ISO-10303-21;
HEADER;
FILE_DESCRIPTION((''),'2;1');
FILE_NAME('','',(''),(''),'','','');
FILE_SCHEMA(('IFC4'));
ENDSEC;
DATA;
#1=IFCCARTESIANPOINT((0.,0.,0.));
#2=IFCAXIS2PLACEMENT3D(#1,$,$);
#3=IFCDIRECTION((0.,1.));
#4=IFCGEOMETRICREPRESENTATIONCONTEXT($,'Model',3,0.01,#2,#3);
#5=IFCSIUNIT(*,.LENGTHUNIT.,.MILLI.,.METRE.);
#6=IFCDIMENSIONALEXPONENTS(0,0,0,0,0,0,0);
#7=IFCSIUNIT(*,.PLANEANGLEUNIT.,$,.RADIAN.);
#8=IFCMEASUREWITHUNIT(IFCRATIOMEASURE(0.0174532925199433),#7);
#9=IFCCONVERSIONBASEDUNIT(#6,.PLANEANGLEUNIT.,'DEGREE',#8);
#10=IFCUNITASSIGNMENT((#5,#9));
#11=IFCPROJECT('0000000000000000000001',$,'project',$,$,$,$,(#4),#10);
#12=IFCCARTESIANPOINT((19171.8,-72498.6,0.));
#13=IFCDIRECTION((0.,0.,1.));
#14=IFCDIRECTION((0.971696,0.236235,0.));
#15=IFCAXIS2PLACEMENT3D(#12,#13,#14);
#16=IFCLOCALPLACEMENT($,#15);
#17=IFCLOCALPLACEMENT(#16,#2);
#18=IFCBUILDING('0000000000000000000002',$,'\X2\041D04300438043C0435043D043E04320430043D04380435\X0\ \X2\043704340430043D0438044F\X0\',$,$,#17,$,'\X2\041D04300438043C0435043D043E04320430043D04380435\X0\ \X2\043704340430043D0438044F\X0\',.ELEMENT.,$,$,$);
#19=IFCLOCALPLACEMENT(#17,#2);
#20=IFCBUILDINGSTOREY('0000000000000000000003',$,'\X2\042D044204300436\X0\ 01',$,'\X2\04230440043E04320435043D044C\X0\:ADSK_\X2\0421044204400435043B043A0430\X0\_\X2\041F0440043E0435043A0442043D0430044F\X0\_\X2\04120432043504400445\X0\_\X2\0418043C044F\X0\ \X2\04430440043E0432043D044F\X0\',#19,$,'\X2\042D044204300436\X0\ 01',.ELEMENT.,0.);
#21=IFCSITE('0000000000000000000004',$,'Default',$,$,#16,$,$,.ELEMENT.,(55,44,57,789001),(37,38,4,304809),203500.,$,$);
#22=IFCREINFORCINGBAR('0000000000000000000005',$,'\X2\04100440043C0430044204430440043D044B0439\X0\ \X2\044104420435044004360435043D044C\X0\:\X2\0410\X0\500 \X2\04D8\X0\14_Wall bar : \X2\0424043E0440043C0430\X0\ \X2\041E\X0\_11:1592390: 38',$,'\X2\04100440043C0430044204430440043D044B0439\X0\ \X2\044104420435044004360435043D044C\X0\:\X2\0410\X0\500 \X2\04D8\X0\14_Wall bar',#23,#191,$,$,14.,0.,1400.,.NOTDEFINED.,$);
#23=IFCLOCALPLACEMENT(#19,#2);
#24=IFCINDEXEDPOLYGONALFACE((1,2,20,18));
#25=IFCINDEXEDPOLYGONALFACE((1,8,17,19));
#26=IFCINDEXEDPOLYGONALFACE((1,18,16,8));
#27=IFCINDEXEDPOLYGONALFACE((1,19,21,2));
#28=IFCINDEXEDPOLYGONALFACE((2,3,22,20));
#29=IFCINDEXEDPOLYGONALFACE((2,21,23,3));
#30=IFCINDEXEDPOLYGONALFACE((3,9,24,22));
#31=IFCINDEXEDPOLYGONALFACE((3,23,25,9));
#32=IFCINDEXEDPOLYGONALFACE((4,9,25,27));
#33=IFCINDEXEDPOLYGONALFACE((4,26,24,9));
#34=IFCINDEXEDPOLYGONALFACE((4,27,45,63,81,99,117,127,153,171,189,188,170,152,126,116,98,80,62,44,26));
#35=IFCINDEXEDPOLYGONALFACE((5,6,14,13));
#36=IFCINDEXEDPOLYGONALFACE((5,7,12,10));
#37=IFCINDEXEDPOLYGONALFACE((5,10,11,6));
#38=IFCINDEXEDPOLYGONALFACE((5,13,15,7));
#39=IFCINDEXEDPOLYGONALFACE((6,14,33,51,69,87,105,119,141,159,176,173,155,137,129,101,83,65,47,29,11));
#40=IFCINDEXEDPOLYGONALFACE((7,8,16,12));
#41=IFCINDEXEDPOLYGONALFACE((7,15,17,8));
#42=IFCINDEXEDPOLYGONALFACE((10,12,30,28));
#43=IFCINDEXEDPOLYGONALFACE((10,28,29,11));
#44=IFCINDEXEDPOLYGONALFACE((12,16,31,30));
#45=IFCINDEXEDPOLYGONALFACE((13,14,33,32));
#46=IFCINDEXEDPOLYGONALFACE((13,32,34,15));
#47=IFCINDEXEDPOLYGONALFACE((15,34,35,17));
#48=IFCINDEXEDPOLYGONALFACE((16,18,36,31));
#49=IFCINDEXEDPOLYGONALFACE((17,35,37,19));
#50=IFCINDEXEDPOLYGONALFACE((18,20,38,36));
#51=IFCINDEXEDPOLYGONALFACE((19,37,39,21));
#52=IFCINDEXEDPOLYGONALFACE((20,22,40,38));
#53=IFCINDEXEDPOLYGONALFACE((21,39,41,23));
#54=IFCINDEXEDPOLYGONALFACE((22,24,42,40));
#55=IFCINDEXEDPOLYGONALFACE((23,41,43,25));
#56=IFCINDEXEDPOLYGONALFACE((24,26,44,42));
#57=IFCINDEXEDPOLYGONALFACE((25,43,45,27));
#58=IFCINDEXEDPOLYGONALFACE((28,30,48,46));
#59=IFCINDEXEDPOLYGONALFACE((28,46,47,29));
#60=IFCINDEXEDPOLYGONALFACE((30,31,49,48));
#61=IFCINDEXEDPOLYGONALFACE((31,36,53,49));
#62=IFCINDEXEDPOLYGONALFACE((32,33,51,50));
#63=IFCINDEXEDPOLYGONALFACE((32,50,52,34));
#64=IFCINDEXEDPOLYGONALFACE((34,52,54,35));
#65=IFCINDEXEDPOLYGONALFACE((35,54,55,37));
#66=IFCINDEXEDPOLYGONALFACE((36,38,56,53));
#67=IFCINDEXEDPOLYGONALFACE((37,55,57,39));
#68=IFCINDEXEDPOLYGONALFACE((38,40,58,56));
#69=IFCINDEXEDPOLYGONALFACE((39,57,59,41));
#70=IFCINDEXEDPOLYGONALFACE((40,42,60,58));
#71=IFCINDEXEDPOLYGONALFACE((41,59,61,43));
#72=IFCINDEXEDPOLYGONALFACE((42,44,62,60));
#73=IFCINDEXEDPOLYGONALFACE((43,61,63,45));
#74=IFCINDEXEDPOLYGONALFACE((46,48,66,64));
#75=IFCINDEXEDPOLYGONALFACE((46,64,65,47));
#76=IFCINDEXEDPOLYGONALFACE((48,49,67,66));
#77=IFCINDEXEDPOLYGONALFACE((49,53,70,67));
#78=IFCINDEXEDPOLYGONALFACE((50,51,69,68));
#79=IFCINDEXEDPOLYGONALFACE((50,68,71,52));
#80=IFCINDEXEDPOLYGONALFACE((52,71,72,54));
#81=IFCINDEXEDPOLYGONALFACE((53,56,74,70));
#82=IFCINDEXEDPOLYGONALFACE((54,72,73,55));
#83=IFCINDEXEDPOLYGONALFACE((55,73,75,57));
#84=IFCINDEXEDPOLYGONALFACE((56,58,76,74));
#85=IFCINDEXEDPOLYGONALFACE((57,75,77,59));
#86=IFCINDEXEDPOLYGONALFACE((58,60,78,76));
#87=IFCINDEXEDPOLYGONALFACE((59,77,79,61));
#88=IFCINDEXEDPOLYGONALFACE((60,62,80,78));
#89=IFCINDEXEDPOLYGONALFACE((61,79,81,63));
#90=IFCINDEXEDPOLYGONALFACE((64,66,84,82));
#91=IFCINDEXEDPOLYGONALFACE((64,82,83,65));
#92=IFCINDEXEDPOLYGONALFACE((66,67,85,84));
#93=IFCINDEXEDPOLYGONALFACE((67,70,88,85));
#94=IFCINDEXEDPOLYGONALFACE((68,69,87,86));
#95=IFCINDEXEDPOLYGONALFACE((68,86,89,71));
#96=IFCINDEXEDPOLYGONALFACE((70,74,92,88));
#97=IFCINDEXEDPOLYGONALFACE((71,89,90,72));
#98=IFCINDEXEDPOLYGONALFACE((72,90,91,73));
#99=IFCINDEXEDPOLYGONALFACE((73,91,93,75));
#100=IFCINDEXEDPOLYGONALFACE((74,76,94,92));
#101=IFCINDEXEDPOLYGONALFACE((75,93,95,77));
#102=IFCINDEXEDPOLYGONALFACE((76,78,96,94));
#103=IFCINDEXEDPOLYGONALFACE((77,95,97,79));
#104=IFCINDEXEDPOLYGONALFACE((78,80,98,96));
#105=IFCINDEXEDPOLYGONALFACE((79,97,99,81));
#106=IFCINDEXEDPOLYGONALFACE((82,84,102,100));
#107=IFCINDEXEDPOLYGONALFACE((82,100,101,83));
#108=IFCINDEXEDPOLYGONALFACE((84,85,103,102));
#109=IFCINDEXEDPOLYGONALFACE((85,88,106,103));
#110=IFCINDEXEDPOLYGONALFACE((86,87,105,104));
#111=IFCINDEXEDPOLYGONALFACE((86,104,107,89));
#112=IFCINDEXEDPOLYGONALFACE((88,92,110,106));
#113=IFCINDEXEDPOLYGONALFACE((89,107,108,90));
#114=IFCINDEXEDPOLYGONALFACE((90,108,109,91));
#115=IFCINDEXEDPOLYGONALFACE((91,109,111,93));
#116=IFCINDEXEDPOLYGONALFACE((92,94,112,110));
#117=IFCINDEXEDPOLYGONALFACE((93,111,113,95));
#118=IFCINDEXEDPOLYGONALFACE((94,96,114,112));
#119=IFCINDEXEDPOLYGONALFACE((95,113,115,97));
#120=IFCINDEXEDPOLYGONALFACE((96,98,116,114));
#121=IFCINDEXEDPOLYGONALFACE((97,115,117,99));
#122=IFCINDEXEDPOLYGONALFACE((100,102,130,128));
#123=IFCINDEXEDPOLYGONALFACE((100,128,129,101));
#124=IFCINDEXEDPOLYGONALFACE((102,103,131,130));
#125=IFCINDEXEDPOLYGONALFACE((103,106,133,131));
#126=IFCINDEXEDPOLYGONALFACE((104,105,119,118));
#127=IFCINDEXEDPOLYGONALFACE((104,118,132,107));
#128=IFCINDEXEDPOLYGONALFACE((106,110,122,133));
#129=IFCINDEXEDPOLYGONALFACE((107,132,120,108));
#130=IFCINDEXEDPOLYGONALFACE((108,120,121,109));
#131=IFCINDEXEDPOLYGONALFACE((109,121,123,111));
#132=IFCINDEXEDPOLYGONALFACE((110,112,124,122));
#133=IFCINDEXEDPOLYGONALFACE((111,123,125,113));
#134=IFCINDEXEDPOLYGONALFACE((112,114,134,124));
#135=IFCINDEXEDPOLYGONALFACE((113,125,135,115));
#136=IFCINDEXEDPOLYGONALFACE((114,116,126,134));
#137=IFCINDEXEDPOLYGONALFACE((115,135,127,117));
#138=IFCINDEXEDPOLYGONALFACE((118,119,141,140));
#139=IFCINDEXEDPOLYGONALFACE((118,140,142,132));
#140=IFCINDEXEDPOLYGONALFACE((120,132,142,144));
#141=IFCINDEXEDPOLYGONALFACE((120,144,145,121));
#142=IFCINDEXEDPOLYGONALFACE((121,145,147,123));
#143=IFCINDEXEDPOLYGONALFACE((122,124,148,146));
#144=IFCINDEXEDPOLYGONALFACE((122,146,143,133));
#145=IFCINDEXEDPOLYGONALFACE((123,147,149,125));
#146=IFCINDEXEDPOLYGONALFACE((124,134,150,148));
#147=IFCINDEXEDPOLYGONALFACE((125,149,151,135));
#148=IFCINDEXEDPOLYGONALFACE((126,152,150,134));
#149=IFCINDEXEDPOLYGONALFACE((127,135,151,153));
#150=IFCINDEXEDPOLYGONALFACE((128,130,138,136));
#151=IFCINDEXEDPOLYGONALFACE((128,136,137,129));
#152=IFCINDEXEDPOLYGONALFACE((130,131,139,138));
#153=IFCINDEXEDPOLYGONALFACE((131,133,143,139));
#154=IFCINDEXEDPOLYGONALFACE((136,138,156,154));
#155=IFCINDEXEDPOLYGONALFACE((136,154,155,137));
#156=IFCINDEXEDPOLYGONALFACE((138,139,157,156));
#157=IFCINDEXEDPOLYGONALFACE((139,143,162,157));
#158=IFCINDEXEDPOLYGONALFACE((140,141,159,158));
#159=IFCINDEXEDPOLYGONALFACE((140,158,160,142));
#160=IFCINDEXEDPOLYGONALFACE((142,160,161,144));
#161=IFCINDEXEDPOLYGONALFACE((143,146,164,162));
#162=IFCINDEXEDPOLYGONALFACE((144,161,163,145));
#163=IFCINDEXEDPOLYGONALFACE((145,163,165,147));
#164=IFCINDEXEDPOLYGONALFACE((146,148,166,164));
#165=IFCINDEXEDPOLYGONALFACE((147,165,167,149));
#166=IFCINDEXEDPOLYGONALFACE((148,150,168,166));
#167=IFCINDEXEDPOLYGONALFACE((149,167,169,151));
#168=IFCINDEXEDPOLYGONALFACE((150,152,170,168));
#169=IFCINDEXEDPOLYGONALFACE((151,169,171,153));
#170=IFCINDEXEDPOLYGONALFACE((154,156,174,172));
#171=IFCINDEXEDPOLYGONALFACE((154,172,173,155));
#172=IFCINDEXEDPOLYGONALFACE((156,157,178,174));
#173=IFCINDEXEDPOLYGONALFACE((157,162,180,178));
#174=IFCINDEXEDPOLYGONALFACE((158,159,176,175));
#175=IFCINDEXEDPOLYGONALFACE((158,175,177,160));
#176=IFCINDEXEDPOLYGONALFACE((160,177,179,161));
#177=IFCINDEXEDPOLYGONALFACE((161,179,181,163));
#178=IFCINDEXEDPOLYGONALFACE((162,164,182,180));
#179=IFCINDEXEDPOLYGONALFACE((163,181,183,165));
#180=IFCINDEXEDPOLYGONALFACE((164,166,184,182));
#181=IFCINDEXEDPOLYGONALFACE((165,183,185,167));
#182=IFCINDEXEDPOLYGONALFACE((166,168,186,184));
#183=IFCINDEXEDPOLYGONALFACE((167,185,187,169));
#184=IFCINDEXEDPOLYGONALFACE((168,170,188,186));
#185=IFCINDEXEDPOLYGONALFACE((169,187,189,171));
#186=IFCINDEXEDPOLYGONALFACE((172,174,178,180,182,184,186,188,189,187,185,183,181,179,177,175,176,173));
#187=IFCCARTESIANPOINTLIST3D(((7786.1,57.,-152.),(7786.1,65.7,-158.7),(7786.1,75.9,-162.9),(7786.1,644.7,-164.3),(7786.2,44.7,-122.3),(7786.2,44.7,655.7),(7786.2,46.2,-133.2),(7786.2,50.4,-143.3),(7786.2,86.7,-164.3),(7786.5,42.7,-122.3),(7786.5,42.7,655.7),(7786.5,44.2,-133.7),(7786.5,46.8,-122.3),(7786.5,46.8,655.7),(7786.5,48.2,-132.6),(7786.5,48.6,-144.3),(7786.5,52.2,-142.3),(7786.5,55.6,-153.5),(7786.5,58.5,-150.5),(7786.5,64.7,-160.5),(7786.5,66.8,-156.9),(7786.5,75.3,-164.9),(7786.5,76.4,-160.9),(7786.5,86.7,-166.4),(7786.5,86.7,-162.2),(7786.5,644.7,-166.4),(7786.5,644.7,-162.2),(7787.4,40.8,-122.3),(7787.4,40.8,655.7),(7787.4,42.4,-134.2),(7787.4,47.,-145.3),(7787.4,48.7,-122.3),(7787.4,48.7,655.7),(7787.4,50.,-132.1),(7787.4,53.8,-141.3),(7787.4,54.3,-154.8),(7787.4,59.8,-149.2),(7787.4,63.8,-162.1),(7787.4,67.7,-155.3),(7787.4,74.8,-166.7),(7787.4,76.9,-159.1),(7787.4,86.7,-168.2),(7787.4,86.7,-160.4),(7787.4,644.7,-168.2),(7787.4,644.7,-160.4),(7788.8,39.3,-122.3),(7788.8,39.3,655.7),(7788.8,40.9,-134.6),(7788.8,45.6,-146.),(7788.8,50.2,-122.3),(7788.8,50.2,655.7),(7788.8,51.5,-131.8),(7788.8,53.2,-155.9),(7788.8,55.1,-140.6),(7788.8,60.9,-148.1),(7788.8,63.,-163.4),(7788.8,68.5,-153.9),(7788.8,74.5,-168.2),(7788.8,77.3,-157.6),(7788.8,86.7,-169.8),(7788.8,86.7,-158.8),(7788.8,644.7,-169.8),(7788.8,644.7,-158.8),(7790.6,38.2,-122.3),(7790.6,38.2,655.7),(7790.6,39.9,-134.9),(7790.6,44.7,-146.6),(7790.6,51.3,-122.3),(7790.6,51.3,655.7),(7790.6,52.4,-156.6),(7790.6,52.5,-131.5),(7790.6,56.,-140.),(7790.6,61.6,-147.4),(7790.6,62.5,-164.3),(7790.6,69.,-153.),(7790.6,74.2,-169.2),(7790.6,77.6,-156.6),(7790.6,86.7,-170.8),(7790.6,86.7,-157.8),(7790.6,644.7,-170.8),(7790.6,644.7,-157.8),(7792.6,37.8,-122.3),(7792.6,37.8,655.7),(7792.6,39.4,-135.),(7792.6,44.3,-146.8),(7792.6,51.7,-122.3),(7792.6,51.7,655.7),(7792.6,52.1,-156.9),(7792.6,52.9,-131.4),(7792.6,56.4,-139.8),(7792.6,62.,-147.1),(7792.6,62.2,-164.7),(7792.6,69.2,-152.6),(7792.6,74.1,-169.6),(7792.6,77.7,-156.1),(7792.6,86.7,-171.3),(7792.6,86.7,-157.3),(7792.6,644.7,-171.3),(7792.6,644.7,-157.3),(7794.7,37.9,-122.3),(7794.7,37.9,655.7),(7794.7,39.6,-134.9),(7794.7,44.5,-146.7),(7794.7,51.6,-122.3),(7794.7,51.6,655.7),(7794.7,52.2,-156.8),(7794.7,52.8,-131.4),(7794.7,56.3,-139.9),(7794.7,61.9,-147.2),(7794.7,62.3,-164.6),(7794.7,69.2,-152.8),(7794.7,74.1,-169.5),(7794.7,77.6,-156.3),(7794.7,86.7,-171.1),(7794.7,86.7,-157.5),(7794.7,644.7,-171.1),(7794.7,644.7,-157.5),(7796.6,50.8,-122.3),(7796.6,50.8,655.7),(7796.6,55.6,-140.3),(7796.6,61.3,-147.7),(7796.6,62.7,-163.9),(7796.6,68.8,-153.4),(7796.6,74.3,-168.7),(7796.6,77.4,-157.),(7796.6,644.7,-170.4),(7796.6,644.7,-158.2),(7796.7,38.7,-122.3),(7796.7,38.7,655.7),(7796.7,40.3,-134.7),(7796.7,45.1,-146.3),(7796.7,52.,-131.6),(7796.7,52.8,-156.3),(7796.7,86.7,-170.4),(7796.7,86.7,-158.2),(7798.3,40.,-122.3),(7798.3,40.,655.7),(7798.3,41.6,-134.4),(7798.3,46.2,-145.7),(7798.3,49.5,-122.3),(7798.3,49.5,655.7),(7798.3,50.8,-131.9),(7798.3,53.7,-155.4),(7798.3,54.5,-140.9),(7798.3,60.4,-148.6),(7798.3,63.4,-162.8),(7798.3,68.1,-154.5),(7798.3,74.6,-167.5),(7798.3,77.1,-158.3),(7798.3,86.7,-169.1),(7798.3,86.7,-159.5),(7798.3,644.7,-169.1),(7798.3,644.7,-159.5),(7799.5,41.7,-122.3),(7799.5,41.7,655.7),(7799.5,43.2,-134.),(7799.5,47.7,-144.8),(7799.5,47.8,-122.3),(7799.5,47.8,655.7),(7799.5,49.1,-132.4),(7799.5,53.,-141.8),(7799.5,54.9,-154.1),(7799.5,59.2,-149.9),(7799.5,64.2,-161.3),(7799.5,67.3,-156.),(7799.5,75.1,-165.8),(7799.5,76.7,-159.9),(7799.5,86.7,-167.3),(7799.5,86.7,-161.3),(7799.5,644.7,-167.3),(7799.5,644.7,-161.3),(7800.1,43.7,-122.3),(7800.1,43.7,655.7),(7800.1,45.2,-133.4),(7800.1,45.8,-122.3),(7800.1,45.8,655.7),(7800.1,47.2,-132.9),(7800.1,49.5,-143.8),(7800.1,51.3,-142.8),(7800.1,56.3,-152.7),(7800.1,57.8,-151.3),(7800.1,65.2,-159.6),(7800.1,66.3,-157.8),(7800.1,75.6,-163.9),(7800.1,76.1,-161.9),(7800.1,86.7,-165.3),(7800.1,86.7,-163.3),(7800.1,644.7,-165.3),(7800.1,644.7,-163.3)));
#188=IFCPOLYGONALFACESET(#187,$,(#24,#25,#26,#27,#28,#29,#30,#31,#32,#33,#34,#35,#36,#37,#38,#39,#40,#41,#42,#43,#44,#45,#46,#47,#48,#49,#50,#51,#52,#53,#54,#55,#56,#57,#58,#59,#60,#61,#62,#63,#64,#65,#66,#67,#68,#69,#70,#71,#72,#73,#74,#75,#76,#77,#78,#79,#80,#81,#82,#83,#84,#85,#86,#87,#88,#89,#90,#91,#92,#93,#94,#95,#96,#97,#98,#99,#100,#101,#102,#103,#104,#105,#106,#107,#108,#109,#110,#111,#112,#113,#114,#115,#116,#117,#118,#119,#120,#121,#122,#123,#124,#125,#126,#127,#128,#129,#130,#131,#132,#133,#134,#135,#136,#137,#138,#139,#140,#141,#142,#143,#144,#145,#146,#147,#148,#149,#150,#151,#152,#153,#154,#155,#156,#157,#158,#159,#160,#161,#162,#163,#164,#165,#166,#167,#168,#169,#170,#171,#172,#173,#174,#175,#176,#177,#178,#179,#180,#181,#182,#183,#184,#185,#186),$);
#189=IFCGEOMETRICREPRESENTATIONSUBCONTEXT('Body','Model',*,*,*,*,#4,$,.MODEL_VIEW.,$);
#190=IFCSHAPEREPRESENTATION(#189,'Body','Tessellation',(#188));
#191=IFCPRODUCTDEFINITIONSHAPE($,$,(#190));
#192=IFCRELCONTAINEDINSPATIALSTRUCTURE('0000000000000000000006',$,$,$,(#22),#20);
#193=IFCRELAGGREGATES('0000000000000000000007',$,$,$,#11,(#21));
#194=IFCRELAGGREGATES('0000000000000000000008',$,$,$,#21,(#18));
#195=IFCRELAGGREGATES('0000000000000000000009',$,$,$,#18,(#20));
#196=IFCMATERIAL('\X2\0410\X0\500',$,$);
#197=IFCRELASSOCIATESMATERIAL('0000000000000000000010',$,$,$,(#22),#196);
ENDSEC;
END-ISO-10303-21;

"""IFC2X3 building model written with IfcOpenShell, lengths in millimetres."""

from ifc_helpers import new_model, entity, si_unit, converted_unit, direction, frame, origin, place, context, subcontext, project, spatial, material, element, save


model = new_model("IFC2X3")

# Units and contexts
model_context = context("Model", 3, precision=0.01, world=origin(), true_north=direction((0.0, 1.0)))
body_context = subcontext(model_context, "Body", "Model", "MODEL_VIEW")
ifc_project = project(units=[si_unit("LENGTHUNIT", "METRE", prefix="MILLI"), converted_unit("PLANEANGLEUNIT", "DEGREE", entity("IfcRatioMeasure", 0.0174532925199433), si_unit("PLANEANGLEUNIT", "RADIAN"), dimensions=[0, 0, 0, 0, 0, 0, 0])], contexts=[model_context])

# Site, building, storey
site_placement = place(None, frame((19171.8, -72498.6, 0.0), z_axis=(0.0, 0.0, 1.0), x_axis=(0.971696, 0.236235, 0.0)))
site = spatial("IfcSite", under=ifc_project, at=site_placement, Name="Default", CompositionType="ELEMENT", RefLatitude=(55, 44, 57, 789001), RefLongitude=(37, 38, 4, 304809), RefElevation=203500.0)
building_placement = place(site_placement, origin())
building = spatial("IfcBuilding", under=site, at=building_placement, Name="Наименование здания", LongName="Наименование здания", CompositionType="ELEMENT")
storey_placement = place(building_placement, origin())
storey = spatial("IfcBuildingStorey", under=building, at=storey_placement, Name="Этаж 01", ObjectType="Уровень:ADSK_Стрелка_Проектная_Вверх_Имя уровня", LongName="Этаж 01", CompositionType="ELEMENT", Elevation=0.0)

# Reinforcing bar
ifc_material = material(Name="А500")
placement = place(storey_placement, origin())
element("IfcReinforcingBar", 1, at=placement, inside=storey, material=ifc_material, Name="Арматурный стержень:А500 Ә14_Wall bar : Форма О_11:1592390: 38", ObjectType="Арматурный стержень:А500 Ә14_Wall bar", BarLength=1400.0, BarRole="NOTDEFINED", CrossSectionArea=0.0, NominalDiameter=14.0, context=body_context, shape_type="AdvancedSweptSolid", body=[
    entity("IfcSweptDiskSolid", entity("IfcCompositeCurve", [entity("IfcCompositeCurveSegment", "CONTINUOUS", True, entity("IfcPolyline", [entity("IfcCartesianPoint", [7793.1, 44.7, 655.7]), entity("IfcCartesianPoint", [7793.1, 44.7, -122.3])])), entity("IfcCompositeCurveSegment", "CONTINUOUS", True, entity("IfcTrimmedCurve", entity("IfcCircle", entity("IfcAxis2Placement3D", entity("IfcCartesianPoint", [7793.1, 86.7, -122.3]), entity("IfcDirection", [1.0, 0.0, 0.0]), entity("IfcDirection", [0.0, 0.0, -1.0])), 42.0), [entity("IfcParameterValue", 270.0)], [entity("IfcParameterValue", 360.0)], True, "PARAMETER")), entity("IfcCompositeCurveSegment", "CONTINUOUS", True, entity("IfcPolyline", [entity("IfcCartesianPoint", [7793.1, 86.7, -164.3]), entity("IfcCartesianPoint", [7793.1, 644.7, -164.3])]))], False), 7.0, None, 0.0, 92.0),
])

save(model, "model.ifc")
